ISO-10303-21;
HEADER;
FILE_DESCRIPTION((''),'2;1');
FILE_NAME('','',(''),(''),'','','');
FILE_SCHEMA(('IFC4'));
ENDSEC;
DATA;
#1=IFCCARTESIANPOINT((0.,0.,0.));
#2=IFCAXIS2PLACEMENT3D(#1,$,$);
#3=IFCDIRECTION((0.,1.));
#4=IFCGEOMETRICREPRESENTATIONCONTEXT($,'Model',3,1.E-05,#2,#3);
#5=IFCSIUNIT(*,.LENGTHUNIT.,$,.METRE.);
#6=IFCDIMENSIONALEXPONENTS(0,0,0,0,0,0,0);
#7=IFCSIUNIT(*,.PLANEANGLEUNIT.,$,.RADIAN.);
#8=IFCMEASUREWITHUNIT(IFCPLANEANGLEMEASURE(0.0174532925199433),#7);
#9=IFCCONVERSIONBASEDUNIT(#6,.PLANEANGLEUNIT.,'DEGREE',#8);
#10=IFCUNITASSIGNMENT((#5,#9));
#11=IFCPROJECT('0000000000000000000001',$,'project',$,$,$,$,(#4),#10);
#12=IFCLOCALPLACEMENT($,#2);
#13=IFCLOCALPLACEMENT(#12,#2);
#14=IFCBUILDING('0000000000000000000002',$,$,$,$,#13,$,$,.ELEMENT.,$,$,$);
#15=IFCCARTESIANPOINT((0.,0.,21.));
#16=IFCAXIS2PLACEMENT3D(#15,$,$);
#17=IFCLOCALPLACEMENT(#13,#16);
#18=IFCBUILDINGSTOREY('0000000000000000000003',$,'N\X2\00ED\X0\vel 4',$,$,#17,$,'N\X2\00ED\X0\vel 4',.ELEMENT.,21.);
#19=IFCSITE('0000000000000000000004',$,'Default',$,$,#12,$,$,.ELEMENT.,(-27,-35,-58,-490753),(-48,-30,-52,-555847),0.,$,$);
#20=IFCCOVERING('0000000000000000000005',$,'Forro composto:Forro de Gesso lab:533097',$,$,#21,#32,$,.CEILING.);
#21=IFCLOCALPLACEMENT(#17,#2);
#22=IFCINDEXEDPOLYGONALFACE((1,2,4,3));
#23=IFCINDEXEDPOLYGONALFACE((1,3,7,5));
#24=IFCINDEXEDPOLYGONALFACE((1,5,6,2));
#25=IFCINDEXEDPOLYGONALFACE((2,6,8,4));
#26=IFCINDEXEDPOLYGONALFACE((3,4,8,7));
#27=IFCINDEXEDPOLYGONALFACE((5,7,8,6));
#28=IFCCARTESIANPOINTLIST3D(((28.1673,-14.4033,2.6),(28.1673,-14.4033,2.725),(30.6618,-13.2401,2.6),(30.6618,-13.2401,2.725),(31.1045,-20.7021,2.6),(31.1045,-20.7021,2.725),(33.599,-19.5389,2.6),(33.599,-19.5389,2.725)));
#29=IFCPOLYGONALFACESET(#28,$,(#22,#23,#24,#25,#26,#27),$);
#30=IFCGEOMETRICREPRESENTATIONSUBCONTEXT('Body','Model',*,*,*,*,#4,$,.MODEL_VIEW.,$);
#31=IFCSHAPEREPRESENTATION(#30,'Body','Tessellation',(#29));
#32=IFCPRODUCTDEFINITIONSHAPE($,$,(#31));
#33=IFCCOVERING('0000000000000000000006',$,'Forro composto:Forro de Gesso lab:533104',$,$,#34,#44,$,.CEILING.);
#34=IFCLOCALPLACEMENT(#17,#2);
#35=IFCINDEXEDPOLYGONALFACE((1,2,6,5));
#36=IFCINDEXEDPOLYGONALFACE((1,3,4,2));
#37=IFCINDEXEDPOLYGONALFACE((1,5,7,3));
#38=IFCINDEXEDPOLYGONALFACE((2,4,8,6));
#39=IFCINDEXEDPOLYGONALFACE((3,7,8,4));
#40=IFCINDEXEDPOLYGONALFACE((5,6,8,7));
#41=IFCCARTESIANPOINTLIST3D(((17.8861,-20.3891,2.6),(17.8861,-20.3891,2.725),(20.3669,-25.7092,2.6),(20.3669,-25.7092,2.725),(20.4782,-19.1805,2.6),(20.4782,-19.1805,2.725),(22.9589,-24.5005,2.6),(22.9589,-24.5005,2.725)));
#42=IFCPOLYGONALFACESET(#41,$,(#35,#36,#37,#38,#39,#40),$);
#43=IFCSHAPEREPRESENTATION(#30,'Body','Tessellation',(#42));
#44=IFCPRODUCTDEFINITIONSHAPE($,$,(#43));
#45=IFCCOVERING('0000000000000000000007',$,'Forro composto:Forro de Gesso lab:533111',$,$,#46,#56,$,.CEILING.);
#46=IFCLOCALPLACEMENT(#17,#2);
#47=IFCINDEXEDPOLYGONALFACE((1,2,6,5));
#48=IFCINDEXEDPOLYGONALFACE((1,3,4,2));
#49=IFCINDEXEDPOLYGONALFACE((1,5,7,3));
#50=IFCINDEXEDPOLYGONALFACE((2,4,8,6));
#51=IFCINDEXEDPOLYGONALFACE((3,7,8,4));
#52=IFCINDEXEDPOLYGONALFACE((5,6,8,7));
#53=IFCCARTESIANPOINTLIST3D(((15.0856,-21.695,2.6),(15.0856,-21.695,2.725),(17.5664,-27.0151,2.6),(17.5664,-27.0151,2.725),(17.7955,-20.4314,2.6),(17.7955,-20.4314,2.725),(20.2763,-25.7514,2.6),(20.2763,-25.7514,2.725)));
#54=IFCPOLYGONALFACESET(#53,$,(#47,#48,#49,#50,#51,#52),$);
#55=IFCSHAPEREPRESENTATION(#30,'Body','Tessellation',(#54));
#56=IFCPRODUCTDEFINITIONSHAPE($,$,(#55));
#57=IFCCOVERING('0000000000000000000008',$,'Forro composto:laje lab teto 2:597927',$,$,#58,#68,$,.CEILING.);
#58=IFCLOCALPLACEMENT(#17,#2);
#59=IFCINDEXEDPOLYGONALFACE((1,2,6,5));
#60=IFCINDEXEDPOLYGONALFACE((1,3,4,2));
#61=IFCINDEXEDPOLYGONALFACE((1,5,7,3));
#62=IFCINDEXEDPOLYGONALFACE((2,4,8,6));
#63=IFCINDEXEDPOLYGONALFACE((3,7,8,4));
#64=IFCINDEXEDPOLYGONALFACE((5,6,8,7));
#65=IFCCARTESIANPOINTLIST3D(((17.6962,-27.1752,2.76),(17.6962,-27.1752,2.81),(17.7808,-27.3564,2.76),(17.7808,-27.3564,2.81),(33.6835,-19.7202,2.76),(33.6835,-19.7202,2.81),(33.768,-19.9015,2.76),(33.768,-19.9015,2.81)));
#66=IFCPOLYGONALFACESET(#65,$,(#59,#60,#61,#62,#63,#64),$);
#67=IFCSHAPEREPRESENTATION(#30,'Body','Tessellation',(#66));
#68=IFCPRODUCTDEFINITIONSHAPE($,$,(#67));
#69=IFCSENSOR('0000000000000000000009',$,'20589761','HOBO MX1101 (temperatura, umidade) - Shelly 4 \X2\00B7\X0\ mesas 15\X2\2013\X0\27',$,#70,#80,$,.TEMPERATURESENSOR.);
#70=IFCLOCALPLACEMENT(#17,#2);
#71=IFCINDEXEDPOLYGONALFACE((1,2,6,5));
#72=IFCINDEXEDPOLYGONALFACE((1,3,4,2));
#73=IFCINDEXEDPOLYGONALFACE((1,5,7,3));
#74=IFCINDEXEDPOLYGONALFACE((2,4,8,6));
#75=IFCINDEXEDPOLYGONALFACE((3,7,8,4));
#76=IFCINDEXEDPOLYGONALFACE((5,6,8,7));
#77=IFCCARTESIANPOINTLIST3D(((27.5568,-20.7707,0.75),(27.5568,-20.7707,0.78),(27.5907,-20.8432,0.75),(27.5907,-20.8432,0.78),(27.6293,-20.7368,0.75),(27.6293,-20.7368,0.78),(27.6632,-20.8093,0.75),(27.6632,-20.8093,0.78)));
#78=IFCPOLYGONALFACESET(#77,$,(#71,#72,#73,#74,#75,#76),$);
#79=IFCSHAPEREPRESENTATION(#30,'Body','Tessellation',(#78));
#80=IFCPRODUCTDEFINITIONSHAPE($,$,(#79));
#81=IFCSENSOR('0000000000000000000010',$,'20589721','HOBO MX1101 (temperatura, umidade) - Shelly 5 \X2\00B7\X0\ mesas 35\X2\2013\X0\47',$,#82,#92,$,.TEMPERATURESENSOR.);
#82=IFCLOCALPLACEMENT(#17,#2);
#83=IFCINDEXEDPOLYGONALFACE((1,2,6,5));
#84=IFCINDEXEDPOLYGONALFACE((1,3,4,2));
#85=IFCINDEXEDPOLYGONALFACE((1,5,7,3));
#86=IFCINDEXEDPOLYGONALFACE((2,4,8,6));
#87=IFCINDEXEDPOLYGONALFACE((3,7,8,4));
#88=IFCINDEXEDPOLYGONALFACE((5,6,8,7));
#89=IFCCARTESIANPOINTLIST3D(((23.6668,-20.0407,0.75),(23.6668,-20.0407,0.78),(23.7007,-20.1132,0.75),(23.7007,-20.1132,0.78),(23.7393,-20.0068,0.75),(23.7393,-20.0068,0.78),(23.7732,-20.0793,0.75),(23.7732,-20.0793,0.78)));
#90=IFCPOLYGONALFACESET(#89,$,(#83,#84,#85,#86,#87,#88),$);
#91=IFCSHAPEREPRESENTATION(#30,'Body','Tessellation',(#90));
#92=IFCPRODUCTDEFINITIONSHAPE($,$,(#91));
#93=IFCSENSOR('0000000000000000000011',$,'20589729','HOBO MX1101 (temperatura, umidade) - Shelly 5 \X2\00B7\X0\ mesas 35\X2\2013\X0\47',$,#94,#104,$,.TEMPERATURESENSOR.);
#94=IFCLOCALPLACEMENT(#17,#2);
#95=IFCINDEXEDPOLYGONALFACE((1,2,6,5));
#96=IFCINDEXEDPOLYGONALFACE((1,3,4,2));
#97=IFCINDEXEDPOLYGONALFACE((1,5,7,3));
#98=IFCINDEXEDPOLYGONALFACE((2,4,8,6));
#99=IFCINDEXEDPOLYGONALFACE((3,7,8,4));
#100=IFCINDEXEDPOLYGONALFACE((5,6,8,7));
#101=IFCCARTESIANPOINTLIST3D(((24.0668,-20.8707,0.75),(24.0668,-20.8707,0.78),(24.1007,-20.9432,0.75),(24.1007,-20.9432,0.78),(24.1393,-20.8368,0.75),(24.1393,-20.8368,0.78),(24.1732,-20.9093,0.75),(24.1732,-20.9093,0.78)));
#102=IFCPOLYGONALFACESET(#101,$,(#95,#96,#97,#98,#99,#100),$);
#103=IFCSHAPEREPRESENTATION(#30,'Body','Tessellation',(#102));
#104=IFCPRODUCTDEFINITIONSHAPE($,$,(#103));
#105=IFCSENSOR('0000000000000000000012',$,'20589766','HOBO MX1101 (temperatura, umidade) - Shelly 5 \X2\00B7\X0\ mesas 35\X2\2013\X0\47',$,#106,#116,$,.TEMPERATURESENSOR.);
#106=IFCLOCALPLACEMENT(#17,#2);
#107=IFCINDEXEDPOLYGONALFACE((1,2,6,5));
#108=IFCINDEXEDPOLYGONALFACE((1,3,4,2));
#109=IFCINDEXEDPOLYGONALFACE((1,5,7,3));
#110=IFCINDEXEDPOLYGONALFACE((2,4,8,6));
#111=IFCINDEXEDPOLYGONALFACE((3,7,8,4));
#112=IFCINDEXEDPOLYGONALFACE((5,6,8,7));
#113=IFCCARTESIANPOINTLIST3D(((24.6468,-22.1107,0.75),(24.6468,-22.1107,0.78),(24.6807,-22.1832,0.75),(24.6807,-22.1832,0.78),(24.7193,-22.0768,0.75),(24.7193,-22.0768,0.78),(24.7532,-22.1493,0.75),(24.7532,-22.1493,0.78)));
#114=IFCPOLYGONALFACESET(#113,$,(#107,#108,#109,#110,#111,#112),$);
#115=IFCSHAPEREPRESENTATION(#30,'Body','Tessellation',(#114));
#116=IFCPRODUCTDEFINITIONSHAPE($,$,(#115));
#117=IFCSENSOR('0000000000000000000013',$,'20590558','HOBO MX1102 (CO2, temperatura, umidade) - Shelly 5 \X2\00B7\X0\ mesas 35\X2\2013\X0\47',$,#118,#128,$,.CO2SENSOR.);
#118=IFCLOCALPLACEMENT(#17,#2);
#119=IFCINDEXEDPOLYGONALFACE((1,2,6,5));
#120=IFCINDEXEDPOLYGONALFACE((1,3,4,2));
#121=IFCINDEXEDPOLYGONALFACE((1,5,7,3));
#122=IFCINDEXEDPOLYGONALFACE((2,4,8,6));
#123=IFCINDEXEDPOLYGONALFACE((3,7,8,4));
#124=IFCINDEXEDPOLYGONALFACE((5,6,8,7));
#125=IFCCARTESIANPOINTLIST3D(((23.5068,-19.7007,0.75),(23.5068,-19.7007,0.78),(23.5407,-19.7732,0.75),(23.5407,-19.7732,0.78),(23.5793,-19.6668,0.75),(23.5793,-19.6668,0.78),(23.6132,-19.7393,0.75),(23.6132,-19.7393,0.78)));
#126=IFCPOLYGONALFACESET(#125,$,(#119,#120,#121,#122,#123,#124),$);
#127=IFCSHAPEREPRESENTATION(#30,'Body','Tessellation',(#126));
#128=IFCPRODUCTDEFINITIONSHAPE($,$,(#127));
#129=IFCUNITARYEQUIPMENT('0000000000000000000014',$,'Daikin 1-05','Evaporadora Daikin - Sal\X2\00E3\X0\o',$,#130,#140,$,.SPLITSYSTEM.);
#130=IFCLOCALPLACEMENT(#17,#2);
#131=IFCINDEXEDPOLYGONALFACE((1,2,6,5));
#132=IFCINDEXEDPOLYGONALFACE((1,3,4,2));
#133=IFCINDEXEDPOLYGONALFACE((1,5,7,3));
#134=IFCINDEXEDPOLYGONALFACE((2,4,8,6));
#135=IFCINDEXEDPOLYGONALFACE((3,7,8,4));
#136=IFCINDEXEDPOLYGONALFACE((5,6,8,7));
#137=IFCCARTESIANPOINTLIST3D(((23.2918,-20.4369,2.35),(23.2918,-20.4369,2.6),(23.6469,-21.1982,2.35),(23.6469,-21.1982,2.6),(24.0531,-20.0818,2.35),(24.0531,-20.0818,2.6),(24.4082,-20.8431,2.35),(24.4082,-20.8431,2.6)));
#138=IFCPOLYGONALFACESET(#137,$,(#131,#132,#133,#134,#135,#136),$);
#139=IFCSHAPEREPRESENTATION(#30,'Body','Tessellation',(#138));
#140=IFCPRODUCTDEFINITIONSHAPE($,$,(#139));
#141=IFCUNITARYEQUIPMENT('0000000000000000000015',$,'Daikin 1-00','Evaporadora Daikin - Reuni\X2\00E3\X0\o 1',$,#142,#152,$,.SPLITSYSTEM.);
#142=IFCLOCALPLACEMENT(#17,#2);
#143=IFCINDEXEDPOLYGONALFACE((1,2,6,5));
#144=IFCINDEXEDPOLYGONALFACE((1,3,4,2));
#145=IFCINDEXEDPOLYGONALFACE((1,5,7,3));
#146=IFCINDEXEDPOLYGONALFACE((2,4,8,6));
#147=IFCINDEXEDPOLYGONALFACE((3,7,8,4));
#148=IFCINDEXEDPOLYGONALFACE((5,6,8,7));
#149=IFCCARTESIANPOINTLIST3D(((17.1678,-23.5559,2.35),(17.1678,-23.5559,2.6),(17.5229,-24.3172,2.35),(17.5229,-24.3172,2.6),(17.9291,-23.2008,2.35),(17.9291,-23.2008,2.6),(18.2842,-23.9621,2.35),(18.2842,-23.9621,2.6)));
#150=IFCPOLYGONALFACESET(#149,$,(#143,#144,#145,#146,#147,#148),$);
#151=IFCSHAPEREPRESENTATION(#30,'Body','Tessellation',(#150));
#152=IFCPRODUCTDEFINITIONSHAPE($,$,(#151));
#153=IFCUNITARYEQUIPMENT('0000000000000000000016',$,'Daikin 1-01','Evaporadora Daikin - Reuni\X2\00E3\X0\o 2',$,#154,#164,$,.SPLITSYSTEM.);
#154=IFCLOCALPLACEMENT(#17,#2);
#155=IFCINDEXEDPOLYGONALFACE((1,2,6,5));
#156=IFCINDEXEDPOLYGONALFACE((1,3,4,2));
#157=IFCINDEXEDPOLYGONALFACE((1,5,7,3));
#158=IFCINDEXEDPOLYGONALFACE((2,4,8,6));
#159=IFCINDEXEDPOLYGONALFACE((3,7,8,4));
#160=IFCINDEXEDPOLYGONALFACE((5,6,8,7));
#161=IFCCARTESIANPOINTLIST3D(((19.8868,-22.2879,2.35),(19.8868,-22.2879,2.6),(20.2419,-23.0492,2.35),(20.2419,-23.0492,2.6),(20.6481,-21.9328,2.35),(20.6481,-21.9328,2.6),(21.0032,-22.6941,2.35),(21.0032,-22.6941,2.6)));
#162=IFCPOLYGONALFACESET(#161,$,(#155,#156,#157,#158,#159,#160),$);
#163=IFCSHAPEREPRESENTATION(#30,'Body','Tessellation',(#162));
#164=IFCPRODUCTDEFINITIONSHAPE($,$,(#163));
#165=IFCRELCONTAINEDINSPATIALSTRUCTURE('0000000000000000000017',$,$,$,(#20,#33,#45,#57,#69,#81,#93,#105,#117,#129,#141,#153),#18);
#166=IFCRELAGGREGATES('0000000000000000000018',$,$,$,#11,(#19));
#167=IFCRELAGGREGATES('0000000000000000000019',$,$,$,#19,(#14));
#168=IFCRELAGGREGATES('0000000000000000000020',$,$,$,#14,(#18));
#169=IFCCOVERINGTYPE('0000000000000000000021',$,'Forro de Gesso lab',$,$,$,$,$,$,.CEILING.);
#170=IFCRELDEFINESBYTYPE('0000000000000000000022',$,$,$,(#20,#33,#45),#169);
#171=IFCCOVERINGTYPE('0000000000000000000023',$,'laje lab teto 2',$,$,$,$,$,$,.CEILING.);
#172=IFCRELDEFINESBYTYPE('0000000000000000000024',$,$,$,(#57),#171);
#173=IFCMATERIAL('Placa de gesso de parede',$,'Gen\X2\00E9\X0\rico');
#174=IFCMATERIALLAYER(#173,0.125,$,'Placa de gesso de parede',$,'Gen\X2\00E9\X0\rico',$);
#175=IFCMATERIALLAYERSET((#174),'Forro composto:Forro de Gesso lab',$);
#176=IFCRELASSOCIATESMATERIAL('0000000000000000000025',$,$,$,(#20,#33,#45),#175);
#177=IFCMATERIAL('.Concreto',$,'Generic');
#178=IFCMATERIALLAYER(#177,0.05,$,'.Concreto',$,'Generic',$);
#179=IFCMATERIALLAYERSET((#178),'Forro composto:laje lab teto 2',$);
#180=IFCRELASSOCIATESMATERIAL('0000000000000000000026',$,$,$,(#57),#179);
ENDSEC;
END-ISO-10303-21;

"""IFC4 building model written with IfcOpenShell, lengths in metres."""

from ifc_helpers import new_model, entity, si_unit, converted_unit, direction, frame, frame_2d, origin, origin_2d, origin_2d_with_axis, place, context, subcontext, project, spatial, rectangle, extrude, material, layer, layer_set, layer_usage, type_object, element, save


model = new_model("IFC4")

# Units and contexts
model_context = context("Model", 3, precision=1e-05, world=origin(), true_north=direction((0.0, 1.0)))
body_context = subcontext(model_context, "Body", "Model", "MODEL_VIEW")
ifc_project = project(units=[si_unit("LENGTHUNIT", "METRE"), converted_unit("PLANEANGLEUNIT", "DEGREE", entity("IfcPlaneAngleMeasure", 0.0174532925199433), si_unit("PLANEANGLEUNIT", "RADIAN"), dimensions=[0, 0, 0, 0, 0, 0, 0])], contexts=[model_context])

# Site, building, storey
site_placement = place(None, origin())
site = spatial("IfcSite", under=ifc_project, at=site_placement, Name="Default", CompositionType="ELEMENT", RefLatitude=(-27, -35, -58, -490753), RefLongitude=(-48, -30, -52, -555847), RefElevation=0.0)
building_placement = place(site_placement, origin())
building = spatial("IfcBuilding", under=site, at=building_placement, CompositionType="ELEMENT")
storey_placement = place(building_placement, frame((0.0, 0.0, 21.0)))
storey = spatial("IfcBuildingStorey", under=building, at=storey_placement, Name="Nível 4", LongName="Nível 4", CompositionType="ELEMENT", Elevation=21.0)

# Shared definitions
ifc_material_1 = material(Name=".Concreto", Category="Generic")

# Shared definitions
ifc_material_2 = material(Name="Placa de gesso de parede", Category="Genérico")

# Coverings
ifc_layer_1 = layer(ifc_material_2, 0.125, Name="Placa de gesso de parede", Category="Genérico")
ifc_layer_set_1 = layer_set([ifc_layer_1], Name="Forro composto:Forro de Gesso lab")
ifc_layer_usage_1 = layer_usage(ifc_layer_set_1, "AXIS3", "NEGATIVE", 0.0)
covering_type_1 = type_object("IfcCoveringType", Name="Forro de Gesso lab", PredefinedType="CEILING")
covering_1_placement = place(storey_placement, frame((28.1673, -20.7021, 2.6), z_axis=(0.0, 0.0, 1.0), x_axis=(1.0, 0.0, 0.0)))
element("IfcCovering", 1, at=covering_1_placement, inside=storey, type_object=covering_type_1, material=ifc_layer_usage_1, Name="Forro composto:Forro de Gesso lab:533097", PredefinedType="CEILING", context=body_context, shape_type="SweptSolid", body=[
    extrude(rectangle(XDim=2.7524, YDim=6.95, at=origin_2d_with_axis()), frame((2.7159, 3.731, 0.0), z_axis=(0.0, 0.0, 1.0), x_axis=(-0.906308, -0.422618, 0.0)), (0.0, 0.0, 1.0), 0.125),
])
ifc_layer_usage_2 = layer_usage(ifc_layer_set_1, "AXIS3", "NEGATIVE", 0.0)
covering_2_placement = place(storey_placement, frame((17.8861, -25.7092, 2.6), z_axis=(0.0, 0.0, 1.0), x_axis=(1.0, 0.0, 0.0)))
element("IfcCovering", 2, at=covering_2_placement, inside=storey, type_object=covering_type_1, material=ifc_layer_usage_2, Name="Forro composto:Forro de Gesso lab:533104", PredefinedType="CEILING", context=body_context, shape_type="SweptSolid", body=[
    extrude(rectangle(XDim=5.87, YDim=2.86, at=frame_2d((0.0, 0.0), x_axis=(1.0, 0.0))), frame((2.5364, 3.2644, 0.0), z_axis=(0.0, 0.0, 1.0), x_axis=(-0.422618, 0.906308, 0.0)), (0.0, 0.0, 1.0), 0.125),
])
ifc_layer_usage_3 = layer_usage(ifc_layer_set_1, "AXIS3", "NEGATIVE", 0.0)
covering_3_placement = place(storey_placement, frame((15.0856, -27.0151, 2.6), z_axis=(0.0, 0.0, 1.0), x_axis=(1.0, 0.0, 0.0)))
element("IfcCovering", 3, at=covering_3_placement, inside=storey, type_object=covering_type_1, material=ifc_layer_usage_3, Name="Forro composto:Forro de Gesso lab:533111", PredefinedType="CEILING", context=body_context, shape_type="SweptSolid", body=[
    extrude(rectangle(XDim=5.87, YDim=2.99, at=origin_2d_with_axis()), frame((2.5953, 3.2918, 0.0), z_axis=(0.0, 0.0, 1.0), x_axis=(-0.422618, 0.906308, 0.0)), (0.0, 0.0, 1.0), 0.125),
])
ifc_layer_2 = layer(ifc_material_1, 0.05, Name=".Concreto", Category="Generic")
ifc_layer_set_2 = layer_set([ifc_layer_2], Name="Forro composto:laje lab teto 2")
ifc_layer_usage_4 = layer_usage(ifc_layer_set_2, "AXIS3", "NEGATIVE", 0.0)
covering_type_2 = type_object("IfcCoveringType", Name="laje lab teto 2", PredefinedType="CEILING")
covering_4_placement = place(storey_placement, frame((17.6962, -27.3564, 2.76), z_axis=(0.0, 0.0, 1.0), x_axis=(1.0, 0.0, 0.0)))
element("IfcCovering", 4, at=covering_4_placement, inside=storey, type_object=covering_type_2, material=ifc_layer_usage_4, Name="Forro composto:laje lab teto 2:597927", PredefinedType="CEILING", context=body_context, shape_type="SweptSolid", body=[
    extrude(rectangle(XDim=0.2, YDim=17.64, at=frame_2d((0.0, 0.0), x_axis=(1.0, 0.0))), frame((8.0359, 3.8181, 0.0), z_axis=(0.0, 0.0, 1.0), x_axis=(0.422618, -0.906308, 0.0)), (0.0, 0.0, 1.0), 0.05),
])

# Sensors
for number, where, z_axis, x_axis, name, description in (
    (5, (27.61, -20.79, 21.75), (0.0, 0.0, 1.0), (0.906245, 0.422754, 0.0), "20589761", "HOBO MX1101 (temperatura, umidade) - Shelly 4 · mesas 15–27"),
    (6, (23.72, -20.06, 21.75), (0.0, 0.0, 1.0), (0.906245, 0.422754, 0.0), "20589721", "HOBO MX1101 (temperatura, umidade) - Shelly 5 · mesas 35–47"),
    (7, (24.12, -20.89, 21.75), (0.0, 0.0, 1.0), (0.906245, 0.422754, 0.0), "20589729", "HOBO MX1101 (temperatura, umidade) - Shelly 5 · mesas 35–47"),
    (8, (24.7, -22.13, 21.75), (0.0, 0.0, 1.0), (0.906245, 0.422754, 0.0), "20589766", "HOBO MX1101 (temperatura, umidade) - Shelly 5 · mesas 35–47"),
):
    element("IfcSensor", number, at=place(None, frame(where, z_axis=z_axis, x_axis=x_axis)), inside=storey, Name=name, Description=description, PredefinedType="TEMPERATURESENSOR", context=body_context, shape_type="SweptSolid", body=[
        extrude(rectangle(XDim=0.08, YDim=0.08, at=origin_2d()), None, (0.0, 0.0, 1.0), 0.03),
    ])
sensor_placement = place(None, frame((23.56, -19.72, 21.75), z_axis=(0.0, 0.0, 1.0), x_axis=(0.906245, 0.422754, 0.0)))
element("IfcSensor", 9, at=sensor_placement, inside=storey, Name="20590558", Description="HOBO MX1102 (CO2, temperatura, umidade) - Shelly 5 · mesas 35–47", PredefinedType="CO2SENSOR", context=body_context, shape_type="SweptSolid", body=[
    extrude(rectangle(XDim=0.08, YDim=0.08, at=origin_2d()), None, (0.0, 0.0, 1.0), 0.03),
])

# Unitary equipment
for number, where, z_axis, x_axis, name, description in (
    (10, (23.85, -20.64, 23.35), (0.0, 0.0, 1.0), (0.906245, 0.422754, 0.0), "Daikin 1-05", "Evaporadora Daikin - Salão"),
    (11, (17.726, -23.759, 23.35), (0.0, 0.0, 1.0), (0.906245, 0.422754, 0.0), "Daikin 1-00", "Evaporadora Daikin - Reunião 1"),
    (12, (20.445, -22.491, 23.35), (0.0, 0.0, 1.0), (0.906245, 0.422754, 0.0), "Daikin 1-01", "Evaporadora Daikin - Reunião 2"),
):
    element("IfcUnitaryEquipment", number, at=place(None, frame(where, z_axis=z_axis, x_axis=x_axis)), inside=storey, Name=name, Description=description, PredefinedType="SPLITSYSTEM", context=body_context, shape_type="SweptSolid", body=[
        extrude(rectangle(XDim=0.84, YDim=0.84, at=origin_2d()), None, (0.0, 0.0, 1.0), 0.25),
    ])

save(model, "model.ifc")
